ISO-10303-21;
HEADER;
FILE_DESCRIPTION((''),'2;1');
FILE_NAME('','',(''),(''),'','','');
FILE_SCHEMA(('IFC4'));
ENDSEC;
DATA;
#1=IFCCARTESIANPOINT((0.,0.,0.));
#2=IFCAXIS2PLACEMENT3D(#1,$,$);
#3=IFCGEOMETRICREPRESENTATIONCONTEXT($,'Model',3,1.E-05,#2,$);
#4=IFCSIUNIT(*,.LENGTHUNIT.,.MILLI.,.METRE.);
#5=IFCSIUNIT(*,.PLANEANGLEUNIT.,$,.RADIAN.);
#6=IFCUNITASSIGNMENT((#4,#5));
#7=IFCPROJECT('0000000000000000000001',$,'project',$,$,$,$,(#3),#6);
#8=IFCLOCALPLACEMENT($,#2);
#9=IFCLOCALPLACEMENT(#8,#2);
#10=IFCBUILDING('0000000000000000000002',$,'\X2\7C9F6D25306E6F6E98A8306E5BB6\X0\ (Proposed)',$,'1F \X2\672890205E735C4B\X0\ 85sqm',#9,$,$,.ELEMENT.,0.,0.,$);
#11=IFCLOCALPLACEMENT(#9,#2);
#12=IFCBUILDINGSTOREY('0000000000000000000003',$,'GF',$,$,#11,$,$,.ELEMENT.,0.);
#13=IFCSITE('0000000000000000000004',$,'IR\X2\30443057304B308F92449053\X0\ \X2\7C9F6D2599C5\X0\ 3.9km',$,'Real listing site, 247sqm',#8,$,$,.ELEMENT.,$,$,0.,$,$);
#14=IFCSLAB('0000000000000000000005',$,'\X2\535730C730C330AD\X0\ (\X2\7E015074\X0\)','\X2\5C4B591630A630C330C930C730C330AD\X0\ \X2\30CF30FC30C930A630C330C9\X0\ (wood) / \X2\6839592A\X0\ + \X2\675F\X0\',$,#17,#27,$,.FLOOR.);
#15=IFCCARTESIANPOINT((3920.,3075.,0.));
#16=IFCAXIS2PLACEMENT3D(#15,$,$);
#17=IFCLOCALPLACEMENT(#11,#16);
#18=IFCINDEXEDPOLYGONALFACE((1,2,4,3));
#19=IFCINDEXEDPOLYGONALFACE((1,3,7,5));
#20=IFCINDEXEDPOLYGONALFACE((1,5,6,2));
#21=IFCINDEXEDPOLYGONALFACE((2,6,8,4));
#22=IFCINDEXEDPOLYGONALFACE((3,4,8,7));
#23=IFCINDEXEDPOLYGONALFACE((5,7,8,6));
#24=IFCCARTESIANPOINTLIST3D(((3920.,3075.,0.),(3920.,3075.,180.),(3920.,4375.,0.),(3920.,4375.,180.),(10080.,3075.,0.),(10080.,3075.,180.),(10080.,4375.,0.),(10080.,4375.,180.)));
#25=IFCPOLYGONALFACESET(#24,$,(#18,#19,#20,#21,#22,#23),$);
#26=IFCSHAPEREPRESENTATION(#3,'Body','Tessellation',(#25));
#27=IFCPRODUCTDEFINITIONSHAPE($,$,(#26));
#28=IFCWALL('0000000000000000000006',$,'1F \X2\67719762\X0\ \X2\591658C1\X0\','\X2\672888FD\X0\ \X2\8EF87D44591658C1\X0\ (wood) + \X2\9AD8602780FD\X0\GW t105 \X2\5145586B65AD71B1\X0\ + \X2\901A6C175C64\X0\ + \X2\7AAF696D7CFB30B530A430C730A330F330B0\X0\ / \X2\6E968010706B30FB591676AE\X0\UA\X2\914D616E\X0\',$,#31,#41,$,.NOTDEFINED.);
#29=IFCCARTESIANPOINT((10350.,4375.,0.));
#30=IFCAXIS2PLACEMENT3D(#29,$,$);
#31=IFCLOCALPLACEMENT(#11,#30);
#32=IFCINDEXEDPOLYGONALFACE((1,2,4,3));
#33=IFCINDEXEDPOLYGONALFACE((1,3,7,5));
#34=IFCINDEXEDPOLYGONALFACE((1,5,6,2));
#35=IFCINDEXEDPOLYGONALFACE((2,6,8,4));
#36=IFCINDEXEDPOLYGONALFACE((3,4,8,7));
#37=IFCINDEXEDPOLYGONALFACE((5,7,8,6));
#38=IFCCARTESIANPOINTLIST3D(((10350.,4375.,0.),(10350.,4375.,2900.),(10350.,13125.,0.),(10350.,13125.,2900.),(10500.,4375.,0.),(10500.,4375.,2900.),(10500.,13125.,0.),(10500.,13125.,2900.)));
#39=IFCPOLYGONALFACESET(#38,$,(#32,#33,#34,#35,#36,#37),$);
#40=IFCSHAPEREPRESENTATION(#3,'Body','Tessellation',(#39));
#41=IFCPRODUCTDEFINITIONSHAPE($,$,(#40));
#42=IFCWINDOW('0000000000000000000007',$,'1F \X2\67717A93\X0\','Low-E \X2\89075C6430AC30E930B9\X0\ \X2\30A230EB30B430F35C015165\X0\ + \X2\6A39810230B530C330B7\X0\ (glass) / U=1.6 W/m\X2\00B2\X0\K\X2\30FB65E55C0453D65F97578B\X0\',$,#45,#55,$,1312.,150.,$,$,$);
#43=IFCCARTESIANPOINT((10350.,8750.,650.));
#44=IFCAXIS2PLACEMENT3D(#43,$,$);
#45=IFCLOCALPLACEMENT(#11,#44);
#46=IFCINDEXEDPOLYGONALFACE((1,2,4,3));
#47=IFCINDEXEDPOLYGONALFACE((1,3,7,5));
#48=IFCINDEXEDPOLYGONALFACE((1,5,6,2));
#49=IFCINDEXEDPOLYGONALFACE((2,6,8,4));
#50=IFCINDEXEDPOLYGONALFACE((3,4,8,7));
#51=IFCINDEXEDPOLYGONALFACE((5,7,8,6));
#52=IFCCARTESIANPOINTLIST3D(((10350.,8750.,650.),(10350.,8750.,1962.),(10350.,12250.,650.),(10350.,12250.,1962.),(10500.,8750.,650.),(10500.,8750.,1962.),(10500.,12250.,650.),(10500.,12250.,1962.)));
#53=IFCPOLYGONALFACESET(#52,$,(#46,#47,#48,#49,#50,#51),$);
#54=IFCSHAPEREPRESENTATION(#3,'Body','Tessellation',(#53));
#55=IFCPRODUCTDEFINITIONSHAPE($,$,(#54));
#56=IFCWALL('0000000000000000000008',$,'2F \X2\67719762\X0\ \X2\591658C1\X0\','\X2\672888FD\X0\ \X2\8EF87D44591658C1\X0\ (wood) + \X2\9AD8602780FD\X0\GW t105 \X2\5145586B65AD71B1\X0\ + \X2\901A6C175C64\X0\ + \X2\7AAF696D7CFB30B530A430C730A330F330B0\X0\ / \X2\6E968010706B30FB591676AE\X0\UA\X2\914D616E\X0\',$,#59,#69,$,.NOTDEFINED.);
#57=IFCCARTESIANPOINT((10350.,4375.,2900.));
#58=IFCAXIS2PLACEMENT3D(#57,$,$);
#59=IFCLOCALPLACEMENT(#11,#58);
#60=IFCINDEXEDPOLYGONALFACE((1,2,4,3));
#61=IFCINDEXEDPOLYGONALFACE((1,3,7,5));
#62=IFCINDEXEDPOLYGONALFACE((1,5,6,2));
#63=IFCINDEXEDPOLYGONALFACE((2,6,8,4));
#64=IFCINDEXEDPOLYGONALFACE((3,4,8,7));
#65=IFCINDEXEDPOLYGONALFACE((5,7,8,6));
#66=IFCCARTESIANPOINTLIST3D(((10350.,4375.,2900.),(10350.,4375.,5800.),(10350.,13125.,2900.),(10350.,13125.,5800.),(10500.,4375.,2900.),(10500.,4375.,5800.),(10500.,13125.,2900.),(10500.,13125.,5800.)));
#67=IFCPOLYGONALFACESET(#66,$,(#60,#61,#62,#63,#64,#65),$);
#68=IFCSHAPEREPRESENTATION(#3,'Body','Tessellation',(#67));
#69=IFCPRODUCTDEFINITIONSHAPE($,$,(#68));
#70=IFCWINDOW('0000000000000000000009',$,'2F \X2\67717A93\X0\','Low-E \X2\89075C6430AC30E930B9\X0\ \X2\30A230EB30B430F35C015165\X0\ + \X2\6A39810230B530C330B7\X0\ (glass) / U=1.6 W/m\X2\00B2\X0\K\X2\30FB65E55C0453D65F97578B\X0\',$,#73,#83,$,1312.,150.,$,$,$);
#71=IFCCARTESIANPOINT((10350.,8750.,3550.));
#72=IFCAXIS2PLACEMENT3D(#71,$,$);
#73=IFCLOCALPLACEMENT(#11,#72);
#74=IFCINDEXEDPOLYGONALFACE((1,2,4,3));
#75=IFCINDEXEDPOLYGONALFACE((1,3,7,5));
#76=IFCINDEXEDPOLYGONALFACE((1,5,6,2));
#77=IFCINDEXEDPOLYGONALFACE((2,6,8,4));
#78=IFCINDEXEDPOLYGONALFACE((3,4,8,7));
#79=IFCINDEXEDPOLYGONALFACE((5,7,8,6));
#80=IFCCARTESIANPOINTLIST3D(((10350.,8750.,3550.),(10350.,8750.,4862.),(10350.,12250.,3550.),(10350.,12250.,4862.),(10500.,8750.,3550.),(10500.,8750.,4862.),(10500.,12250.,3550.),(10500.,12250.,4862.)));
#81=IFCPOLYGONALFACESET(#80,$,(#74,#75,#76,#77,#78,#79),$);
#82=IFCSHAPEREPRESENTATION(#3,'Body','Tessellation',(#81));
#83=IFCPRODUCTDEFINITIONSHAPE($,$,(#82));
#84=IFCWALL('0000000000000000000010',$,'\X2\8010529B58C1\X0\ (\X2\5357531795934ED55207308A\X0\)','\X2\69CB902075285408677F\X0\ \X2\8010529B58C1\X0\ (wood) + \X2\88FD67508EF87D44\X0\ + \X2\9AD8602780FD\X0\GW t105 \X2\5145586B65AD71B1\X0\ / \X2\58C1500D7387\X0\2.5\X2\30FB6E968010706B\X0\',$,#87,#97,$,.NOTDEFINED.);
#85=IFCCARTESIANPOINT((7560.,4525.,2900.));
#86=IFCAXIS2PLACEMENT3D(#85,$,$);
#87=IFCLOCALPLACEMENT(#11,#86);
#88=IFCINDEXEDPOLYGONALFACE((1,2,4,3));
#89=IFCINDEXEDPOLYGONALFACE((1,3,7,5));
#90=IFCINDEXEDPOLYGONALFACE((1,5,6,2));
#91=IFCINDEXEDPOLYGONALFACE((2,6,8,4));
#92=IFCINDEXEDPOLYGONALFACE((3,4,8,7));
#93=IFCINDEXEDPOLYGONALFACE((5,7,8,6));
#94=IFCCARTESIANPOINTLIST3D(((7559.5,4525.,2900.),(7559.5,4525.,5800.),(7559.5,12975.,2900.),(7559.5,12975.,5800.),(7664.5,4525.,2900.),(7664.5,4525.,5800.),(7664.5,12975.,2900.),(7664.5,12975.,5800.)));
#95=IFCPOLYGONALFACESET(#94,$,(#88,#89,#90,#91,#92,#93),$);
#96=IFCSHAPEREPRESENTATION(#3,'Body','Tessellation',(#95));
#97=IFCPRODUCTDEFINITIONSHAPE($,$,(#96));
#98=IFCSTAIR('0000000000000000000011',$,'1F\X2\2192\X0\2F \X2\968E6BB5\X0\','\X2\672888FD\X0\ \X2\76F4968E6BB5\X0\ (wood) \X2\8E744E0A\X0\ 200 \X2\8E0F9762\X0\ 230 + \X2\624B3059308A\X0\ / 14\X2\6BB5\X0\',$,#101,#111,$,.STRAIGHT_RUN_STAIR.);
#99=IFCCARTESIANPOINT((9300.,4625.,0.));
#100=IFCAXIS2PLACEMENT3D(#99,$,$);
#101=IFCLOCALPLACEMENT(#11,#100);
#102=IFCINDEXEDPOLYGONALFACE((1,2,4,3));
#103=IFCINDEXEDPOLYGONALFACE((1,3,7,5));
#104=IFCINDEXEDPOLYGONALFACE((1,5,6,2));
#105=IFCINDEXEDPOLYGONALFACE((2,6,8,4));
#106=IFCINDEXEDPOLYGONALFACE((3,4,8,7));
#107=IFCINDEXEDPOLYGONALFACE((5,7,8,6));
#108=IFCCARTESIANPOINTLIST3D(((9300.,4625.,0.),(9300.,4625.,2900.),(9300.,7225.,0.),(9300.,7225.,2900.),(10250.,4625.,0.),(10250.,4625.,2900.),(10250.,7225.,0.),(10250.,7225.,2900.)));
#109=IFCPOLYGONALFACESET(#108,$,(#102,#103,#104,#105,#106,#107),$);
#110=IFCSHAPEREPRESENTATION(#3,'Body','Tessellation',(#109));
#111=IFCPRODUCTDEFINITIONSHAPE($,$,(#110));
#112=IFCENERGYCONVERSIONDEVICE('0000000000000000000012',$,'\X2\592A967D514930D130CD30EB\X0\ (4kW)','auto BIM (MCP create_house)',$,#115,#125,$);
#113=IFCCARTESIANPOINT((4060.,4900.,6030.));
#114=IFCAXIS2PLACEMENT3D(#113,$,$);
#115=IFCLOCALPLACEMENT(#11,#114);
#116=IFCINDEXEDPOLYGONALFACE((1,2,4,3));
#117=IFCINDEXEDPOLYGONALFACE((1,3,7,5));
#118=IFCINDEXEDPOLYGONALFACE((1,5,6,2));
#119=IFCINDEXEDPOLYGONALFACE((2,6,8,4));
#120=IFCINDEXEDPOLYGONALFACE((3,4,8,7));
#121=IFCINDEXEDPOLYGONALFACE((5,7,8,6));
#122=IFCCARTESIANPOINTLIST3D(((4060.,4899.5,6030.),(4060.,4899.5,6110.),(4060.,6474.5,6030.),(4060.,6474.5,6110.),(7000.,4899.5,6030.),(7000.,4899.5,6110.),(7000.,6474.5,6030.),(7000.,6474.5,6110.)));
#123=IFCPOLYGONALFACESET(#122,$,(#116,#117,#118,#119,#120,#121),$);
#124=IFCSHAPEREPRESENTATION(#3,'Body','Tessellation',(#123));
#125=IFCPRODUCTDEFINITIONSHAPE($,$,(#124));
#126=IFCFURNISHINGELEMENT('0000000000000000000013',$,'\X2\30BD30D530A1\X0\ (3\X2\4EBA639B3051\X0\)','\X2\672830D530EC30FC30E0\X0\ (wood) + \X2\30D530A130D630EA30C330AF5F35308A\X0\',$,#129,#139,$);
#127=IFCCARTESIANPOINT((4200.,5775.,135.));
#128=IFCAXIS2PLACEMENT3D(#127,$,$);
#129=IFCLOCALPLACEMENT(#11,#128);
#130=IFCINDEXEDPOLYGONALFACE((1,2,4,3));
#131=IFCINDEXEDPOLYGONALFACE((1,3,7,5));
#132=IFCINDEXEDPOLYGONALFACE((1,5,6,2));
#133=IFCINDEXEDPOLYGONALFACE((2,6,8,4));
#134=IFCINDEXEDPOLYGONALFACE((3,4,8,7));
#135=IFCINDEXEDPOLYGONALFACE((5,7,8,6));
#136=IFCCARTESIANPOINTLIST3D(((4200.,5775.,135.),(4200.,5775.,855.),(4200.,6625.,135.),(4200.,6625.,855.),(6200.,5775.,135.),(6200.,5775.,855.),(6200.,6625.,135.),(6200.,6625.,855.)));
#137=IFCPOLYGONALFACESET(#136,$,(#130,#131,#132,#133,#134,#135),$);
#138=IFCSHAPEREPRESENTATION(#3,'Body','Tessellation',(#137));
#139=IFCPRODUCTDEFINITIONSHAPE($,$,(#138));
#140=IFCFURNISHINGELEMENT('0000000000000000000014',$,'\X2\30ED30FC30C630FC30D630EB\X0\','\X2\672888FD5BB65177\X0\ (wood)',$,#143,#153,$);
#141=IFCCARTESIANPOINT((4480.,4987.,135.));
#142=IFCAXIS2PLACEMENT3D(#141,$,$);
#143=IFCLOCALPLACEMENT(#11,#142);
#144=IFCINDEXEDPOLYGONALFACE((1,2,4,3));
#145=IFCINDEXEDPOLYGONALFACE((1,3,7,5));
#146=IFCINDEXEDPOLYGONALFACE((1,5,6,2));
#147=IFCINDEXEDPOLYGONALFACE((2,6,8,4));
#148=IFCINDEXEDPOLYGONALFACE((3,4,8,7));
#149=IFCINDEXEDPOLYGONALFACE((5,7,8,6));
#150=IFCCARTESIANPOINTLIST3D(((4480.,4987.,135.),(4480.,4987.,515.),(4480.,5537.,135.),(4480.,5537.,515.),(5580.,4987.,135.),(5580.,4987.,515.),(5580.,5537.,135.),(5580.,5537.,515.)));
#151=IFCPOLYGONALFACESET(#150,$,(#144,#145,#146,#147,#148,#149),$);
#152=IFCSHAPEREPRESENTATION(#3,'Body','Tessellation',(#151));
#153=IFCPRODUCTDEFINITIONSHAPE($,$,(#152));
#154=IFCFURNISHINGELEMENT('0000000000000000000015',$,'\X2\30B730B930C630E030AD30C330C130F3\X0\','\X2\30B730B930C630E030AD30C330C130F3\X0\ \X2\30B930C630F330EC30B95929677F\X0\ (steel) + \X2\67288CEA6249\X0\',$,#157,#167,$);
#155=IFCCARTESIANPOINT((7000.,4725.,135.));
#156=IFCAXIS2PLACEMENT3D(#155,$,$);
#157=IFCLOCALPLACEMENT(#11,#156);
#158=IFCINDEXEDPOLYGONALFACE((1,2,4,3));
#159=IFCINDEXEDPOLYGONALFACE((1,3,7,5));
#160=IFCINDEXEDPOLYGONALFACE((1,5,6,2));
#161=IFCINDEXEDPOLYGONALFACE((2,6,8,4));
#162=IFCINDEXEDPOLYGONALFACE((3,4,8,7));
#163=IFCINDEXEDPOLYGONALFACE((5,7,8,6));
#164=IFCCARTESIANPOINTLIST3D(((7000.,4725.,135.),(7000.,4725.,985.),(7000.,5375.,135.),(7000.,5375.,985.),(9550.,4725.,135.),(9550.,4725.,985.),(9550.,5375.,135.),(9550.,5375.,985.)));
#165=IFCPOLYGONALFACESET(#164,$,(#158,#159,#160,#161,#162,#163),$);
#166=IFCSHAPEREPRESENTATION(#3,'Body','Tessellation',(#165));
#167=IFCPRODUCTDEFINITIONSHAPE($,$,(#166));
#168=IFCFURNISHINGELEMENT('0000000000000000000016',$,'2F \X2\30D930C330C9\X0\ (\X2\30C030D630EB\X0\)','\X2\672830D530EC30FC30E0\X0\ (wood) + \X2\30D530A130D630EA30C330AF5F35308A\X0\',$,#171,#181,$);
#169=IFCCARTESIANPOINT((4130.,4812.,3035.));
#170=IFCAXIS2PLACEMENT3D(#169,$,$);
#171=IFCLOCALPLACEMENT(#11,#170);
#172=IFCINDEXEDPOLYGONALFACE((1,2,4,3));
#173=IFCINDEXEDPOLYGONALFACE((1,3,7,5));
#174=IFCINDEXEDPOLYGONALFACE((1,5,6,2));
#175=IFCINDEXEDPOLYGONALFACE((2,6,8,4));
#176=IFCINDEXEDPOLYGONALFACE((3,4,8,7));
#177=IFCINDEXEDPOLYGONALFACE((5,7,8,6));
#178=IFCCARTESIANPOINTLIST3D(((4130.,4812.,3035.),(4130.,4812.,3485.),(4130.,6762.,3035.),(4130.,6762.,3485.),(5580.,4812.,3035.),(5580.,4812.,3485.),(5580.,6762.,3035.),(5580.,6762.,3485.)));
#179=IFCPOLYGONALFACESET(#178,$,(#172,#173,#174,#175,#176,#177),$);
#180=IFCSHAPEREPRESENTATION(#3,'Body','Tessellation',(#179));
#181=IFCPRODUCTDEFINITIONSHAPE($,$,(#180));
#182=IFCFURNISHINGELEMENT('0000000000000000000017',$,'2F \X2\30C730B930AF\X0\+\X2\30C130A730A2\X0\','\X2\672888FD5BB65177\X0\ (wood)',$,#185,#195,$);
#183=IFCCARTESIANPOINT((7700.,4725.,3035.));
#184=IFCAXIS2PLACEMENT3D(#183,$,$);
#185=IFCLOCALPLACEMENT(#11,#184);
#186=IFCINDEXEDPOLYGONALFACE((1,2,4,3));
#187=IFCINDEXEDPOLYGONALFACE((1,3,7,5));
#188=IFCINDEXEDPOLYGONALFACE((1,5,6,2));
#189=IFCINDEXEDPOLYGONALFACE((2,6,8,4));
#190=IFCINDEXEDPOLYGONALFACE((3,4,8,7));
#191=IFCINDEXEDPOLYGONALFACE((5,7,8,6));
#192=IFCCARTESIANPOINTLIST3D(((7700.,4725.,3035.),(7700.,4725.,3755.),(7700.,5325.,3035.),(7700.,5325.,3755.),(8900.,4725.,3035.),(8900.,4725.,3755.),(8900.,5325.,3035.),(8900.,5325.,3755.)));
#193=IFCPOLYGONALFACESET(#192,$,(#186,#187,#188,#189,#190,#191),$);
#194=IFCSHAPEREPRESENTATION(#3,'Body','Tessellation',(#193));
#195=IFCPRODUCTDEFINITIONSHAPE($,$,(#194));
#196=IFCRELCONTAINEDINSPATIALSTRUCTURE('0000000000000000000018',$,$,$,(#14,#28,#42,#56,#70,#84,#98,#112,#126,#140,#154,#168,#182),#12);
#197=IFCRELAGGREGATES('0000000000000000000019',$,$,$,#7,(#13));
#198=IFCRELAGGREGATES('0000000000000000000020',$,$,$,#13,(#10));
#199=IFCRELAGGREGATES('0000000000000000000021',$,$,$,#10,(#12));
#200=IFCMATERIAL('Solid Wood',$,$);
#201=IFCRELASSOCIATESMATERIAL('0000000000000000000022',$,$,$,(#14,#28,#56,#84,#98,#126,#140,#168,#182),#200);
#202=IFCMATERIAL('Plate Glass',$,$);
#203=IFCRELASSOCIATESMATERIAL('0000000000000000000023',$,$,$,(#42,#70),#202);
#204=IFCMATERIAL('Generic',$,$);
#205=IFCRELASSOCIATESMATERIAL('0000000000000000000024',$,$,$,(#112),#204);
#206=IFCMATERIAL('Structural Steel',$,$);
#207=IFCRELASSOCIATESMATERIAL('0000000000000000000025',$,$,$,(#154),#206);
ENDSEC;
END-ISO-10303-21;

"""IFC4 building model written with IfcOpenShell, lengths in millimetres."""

from ifc_helpers import new_model, si_unit, frame, frame_2d, origin, place, context, project, spatial, rectangle, extrude, material, element, fill, save


model = new_model("IFC4")

# Units and contexts
model_context = context("Model", 3, precision=1e-05, world=origin())
ifc_project = project(units=[si_unit("LENGTHUNIT", "METRE", prefix="MILLI"), si_unit("PLANEANGLEUNIT", "RADIAN")], contexts=[model_context])

# Site, building, storey
site_placement = place(None, origin())
site = spatial("IfcSite", under=ifc_project, at=site_placement, Name="IRいしかわ鉄道 粟津駅 3.9km", ObjectType="Real listing site, 247sqm", CompositionType="ELEMENT", RefElevation=0.0)
building_placement = place(site_placement, origin())
building = spatial("IfcBuilding", under=site, at=building_placement, Name="粟津の潮風の家 (Proposed)", ObjectType="1F 木造平屋 85sqm", CompositionType="ELEMENT", ElevationOfRefHeight=0.0, ElevationOfTerrain=0.0)
storey_placement = place(building_placement, origin())
storey = spatial("IfcBuildingStorey", under=building, at=storey_placement, Name="GF", CompositionType="ELEMENT", Elevation=0.0)

# Slab
ifc_material_1 = material(Name="Solid Wood")
slab_placement = place(storey_placement, frame((3920.0, 3075.0, 0.0)))
element("IfcSlab", 1, at=slab_placement, inside=storey, material=ifc_material_1, Name="南デッキ (縁側)", Description="屋外ウッドデッキ ハードウッド (wood) / 根太 + 束", PredefinedType="FLOOR", context=model_context, shape_type="SweptSolid", body=[
    extrude(rectangle(XDim=6160.0, YDim=1300.0, at=frame_2d((3080.0, 650.0))), frame((3920.0, 3075.0, 0.0)), (0.0, 0.0, 1.0), 180.0),
])

# Wall, opening, window
wall_1_placement = place(storey_placement, frame((10350.0, 4375.0, 0.0)))
wall_1 = element("IfcWall", 2, at=wall_1_placement, inside=storey, material=ifc_material_1, Name="1F 東面 外壁", Description="木製 軸組外壁 (wood) + 高性能GW t105 充填断熱 + 通気層 + 窯業系サイディング / 準耐火・外皮UA配慮", PredefinedType="NOTDEFINED", context=model_context, shape_type="SweptSolid", body=[
    extrude(rectangle(XDim=150.0, YDim=8750.0, at=frame_2d((75.0, 4375.0))), frame((10350.0, 4375.0, 0.0)), (0.0, 0.0, 1.0), 2900.0),
])
opening_1_placement = place(storey_placement, frame((10350.0, 8750.0, 650.0)))
opening_1 = element("IfcOpeningElement", 3, at=opening_1_placement, cuts=wall_1, PredefinedType="NOTDEFINED", context=model_context, shape_type="SweptSolid", body=[
    extrude(rectangle(XDim=150.0, YDim=3500.0, at=frame_2d((75.0, 1750.0))), frame((10350.0, 8750.0, 650.0)), (0.0, 0.0, 1.0), 1312.0),
])
ifc_material_2 = material(Name="Plate Glass")
window_1_placement = place(storey_placement, frame((10350.0, 8750.0, 650.0)))
window_1 = element("IfcWindow", 4, at=window_1_placement, inside=storey, material=ifc_material_2, Name="1F 東窓", Description="Low-E 複層ガラス アルゴン封入 + 樹脂サッシ (glass) / U=1.6 W/m²K・日射取得型", OverallHeight=1312.0, OverallWidth=150.0, context=model_context, shape_type="SweptSolid", body=[
    extrude(rectangle(XDim=150.0, YDim=3500.0, at=frame_2d((75.0, 1750.0))), frame((10350.0, 8750.0, 650.0)), (0.0, 0.0, 1.0), 1312.0),
])
fill(opening_1, window_1)

# Wall, opening, window
wall_2_placement = place(storey_placement, frame((10350.0, 4375.0, 2900.0)))
wall_2 = element("IfcWall", 5, at=wall_2_placement, inside=storey, material=ifc_material_1, Name="2F 東面 外壁", Description="木製 軸組外壁 (wood) + 高性能GW t105 充填断熱 + 通気層 + 窯業系サイディング / 準耐火・外皮UA配慮", PredefinedType="NOTDEFINED", context=model_context, shape_type="SweptSolid", body=[
    extrude(rectangle(XDim=150.0, YDim=8750.0, at=frame_2d((75.0, 4375.0))), frame((10350.0, 4375.0, 2900.0)), (0.0, 0.0, 1.0), 2900.0),
])
opening_2_placement = place(storey_placement, frame((10350.0, 8750.0, 3550.0)))
opening_2 = element("IfcOpeningElement", 6, at=opening_2_placement, cuts=wall_2, PredefinedType="NOTDEFINED", context=model_context, shape_type="SweptSolid", body=[
    extrude(rectangle(XDim=150.0, YDim=3500.0, at=frame_2d((75.0, 1750.0))), frame((10350.0, 8750.0, 3550.0)), (0.0, 0.0, 1.0), 1312.0),
])
window_2_placement = place(storey_placement, frame((10350.0, 8750.0, 3550.0)))
window_2 = element("IfcWindow", 7, at=window_2_placement, inside=storey, material=ifc_material_2, Name="2F 東窓", Description="Low-E 複層ガラス アルゴン封入 + 樹脂サッシ (glass) / U=1.6 W/m²K・日射取得型", OverallHeight=1312.0, OverallWidth=150.0, context=model_context, shape_type="SweptSolid", body=[
    extrude(rectangle(XDim=150.0, YDim=3500.0, at=frame_2d((75.0, 1750.0))), frame((10350.0, 8750.0, 3550.0)), (0.0, 0.0, 1.0), 1312.0),
])
fill(opening_2, window_2)

# Wall
wall_3_placement = place(storey_placement, frame((7560.0, 4525.0, 2900.0)))
element("IfcWall", 8, at=wall_3_placement, inside=storey, material=ifc_material_1, Name="耐力壁 (南北間仕切り)", Description="構造用合板 耐力壁 (wood) + 製材軸組 + 高性能GW t105 充填断熱 / 壁倍率2.5・準耐火", PredefinedType="NOTDEFINED", context=model_context, shape_type="SweptSolid", body=[
    extrude(rectangle(XDim=105.0, YDim=8450.0, at=frame_2d((52.0, 4225.0))), frame((7560.0, 4525.0, 2900.0)), (0.0, 0.0, 1.0), 2900.0),
])

# Stair
stair_placement = place(storey_placement, frame((9300.0, 4625.0, 0.0)))
element("IfcStair", 9, at=stair_placement, inside=storey, material=ifc_material_1, Name="1F→2F 階段", Description="木製 直階段 (wood) 蹴上 200 踏面 230 + 手すり / 14段", PredefinedType="STRAIGHT_RUN_STAIR", context=model_context, shape_type="SweptSolid", body=[
    extrude(rectangle(XDim=950.0, YDim=2600.0, at=frame_2d((475.0, 1300.0))), frame((9300.0, 4625.0, 0.0)), (0.0, 0.0, 1.0), 2900.0),
])

# Energy conversion device
ifc_material_3 = material(Name="Generic")
energy_conversion_device_placement = place(storey_placement, frame((4060.0, 4900.0, 6030.0)))
element("IfcEnergyConversionDevice", 10, at=energy_conversion_device_placement, inside=storey, material=ifc_material_3, Name="太陽光パネル (4kW)", Description="auto BIM (MCP create_house)", context=model_context, shape_type="SweptSolid", body=[
    extrude(rectangle(XDim=2940.0, YDim=1575.0, at=frame_2d((1470.0, 787.0))), frame((4060.0, 4900.0, 6030.0)), (0.0, 0.0, 1.0), 80.0),
])

# Furnishing elements
furnishing_1_placement = place(storey_placement, frame((4200.0, 5775.0, 135.0)))
element("IfcFurnishingElement", 11, at=furnishing_1_placement, inside=storey, material=ifc_material_1, Name="ソファ (3人掛け)", Description="木フレーム (wood) + ファブリック張り", context=model_context, shape_type="SweptSolid", body=[
    extrude(rectangle(XDim=2000.0, YDim=850.0, at=frame_2d((1000.0, 425.0))), frame((4200.0, 5775.0, 135.0)), (0.0, 0.0, 1.0), 720.0),
])
furnishing_2_placement = place(storey_placement, frame((4480.0, 4987.0, 135.0)))
element("IfcFurnishingElement", 12, at=furnishing_2_placement, inside=storey, material=ifc_material_1, Name="ローテーブル", Description="木製家具 (wood)", context=model_context, shape_type="SweptSolid", body=[
    extrude(rectangle(XDim=1100.0, YDim=550.0, at=frame_2d((550.0, 275.0))), frame((4480.0, 4987.0, 135.0)), (0.0, 0.0, 1.0), 380.0),
])
ifc_material_4 = material(Name="Structural Steel")
furnishing_3_placement = place(storey_placement, frame((7000.0, 4725.0, 135.0)))
element("IfcFurnishingElement", 13, at=furnishing_3_placement, inside=storey, material=ifc_material_4, Name="システムキッチン", Description="システムキッチン ステンレス天板 (steel) + 木質扉", context=model_context, shape_type="SweptSolid", body=[
    extrude(rectangle(XDim=2550.0, YDim=650.0, at=frame_2d((1275.0, 325.0))), frame((7000.0, 4725.0, 135.0)), (0.0, 0.0, 1.0), 850.0),
])
furnishing_4_placement = place(storey_placement, frame((4130.0, 4812.0, 3035.0)))
element("IfcFurnishingElement", 14, at=furnishing_4_placement, inside=storey, material=ifc_material_1, Name="2F ベッド (ダブル)", Description="木フレーム (wood) + ファブリック張り", context=model_context, shape_type="SweptSolid", body=[
    extrude(rectangle(XDim=1450.0, YDim=1950.0, at=frame_2d((725.0, 975.0))), frame((4130.0, 4812.0, 3035.0)), (0.0, 0.0, 1.0), 450.0),
])
furnishing_5_placement = place(storey_placement, frame((7700.0, 4725.0, 3035.0)))
element("IfcFurnishingElement", 15, at=furnishing_5_placement, inside=storey, material=ifc_material_1, Name="2F デスク+チェア", Description="木製家具 (wood)", context=model_context, shape_type="SweptSolid", body=[
    extrude(rectangle(XDim=1200.0, YDim=600.0, at=frame_2d((600.0, 300.0))), frame((7700.0, 4725.0, 3035.0)), (0.0, 0.0, 1.0), 720.0),
])

save(model, "model.ifc")
